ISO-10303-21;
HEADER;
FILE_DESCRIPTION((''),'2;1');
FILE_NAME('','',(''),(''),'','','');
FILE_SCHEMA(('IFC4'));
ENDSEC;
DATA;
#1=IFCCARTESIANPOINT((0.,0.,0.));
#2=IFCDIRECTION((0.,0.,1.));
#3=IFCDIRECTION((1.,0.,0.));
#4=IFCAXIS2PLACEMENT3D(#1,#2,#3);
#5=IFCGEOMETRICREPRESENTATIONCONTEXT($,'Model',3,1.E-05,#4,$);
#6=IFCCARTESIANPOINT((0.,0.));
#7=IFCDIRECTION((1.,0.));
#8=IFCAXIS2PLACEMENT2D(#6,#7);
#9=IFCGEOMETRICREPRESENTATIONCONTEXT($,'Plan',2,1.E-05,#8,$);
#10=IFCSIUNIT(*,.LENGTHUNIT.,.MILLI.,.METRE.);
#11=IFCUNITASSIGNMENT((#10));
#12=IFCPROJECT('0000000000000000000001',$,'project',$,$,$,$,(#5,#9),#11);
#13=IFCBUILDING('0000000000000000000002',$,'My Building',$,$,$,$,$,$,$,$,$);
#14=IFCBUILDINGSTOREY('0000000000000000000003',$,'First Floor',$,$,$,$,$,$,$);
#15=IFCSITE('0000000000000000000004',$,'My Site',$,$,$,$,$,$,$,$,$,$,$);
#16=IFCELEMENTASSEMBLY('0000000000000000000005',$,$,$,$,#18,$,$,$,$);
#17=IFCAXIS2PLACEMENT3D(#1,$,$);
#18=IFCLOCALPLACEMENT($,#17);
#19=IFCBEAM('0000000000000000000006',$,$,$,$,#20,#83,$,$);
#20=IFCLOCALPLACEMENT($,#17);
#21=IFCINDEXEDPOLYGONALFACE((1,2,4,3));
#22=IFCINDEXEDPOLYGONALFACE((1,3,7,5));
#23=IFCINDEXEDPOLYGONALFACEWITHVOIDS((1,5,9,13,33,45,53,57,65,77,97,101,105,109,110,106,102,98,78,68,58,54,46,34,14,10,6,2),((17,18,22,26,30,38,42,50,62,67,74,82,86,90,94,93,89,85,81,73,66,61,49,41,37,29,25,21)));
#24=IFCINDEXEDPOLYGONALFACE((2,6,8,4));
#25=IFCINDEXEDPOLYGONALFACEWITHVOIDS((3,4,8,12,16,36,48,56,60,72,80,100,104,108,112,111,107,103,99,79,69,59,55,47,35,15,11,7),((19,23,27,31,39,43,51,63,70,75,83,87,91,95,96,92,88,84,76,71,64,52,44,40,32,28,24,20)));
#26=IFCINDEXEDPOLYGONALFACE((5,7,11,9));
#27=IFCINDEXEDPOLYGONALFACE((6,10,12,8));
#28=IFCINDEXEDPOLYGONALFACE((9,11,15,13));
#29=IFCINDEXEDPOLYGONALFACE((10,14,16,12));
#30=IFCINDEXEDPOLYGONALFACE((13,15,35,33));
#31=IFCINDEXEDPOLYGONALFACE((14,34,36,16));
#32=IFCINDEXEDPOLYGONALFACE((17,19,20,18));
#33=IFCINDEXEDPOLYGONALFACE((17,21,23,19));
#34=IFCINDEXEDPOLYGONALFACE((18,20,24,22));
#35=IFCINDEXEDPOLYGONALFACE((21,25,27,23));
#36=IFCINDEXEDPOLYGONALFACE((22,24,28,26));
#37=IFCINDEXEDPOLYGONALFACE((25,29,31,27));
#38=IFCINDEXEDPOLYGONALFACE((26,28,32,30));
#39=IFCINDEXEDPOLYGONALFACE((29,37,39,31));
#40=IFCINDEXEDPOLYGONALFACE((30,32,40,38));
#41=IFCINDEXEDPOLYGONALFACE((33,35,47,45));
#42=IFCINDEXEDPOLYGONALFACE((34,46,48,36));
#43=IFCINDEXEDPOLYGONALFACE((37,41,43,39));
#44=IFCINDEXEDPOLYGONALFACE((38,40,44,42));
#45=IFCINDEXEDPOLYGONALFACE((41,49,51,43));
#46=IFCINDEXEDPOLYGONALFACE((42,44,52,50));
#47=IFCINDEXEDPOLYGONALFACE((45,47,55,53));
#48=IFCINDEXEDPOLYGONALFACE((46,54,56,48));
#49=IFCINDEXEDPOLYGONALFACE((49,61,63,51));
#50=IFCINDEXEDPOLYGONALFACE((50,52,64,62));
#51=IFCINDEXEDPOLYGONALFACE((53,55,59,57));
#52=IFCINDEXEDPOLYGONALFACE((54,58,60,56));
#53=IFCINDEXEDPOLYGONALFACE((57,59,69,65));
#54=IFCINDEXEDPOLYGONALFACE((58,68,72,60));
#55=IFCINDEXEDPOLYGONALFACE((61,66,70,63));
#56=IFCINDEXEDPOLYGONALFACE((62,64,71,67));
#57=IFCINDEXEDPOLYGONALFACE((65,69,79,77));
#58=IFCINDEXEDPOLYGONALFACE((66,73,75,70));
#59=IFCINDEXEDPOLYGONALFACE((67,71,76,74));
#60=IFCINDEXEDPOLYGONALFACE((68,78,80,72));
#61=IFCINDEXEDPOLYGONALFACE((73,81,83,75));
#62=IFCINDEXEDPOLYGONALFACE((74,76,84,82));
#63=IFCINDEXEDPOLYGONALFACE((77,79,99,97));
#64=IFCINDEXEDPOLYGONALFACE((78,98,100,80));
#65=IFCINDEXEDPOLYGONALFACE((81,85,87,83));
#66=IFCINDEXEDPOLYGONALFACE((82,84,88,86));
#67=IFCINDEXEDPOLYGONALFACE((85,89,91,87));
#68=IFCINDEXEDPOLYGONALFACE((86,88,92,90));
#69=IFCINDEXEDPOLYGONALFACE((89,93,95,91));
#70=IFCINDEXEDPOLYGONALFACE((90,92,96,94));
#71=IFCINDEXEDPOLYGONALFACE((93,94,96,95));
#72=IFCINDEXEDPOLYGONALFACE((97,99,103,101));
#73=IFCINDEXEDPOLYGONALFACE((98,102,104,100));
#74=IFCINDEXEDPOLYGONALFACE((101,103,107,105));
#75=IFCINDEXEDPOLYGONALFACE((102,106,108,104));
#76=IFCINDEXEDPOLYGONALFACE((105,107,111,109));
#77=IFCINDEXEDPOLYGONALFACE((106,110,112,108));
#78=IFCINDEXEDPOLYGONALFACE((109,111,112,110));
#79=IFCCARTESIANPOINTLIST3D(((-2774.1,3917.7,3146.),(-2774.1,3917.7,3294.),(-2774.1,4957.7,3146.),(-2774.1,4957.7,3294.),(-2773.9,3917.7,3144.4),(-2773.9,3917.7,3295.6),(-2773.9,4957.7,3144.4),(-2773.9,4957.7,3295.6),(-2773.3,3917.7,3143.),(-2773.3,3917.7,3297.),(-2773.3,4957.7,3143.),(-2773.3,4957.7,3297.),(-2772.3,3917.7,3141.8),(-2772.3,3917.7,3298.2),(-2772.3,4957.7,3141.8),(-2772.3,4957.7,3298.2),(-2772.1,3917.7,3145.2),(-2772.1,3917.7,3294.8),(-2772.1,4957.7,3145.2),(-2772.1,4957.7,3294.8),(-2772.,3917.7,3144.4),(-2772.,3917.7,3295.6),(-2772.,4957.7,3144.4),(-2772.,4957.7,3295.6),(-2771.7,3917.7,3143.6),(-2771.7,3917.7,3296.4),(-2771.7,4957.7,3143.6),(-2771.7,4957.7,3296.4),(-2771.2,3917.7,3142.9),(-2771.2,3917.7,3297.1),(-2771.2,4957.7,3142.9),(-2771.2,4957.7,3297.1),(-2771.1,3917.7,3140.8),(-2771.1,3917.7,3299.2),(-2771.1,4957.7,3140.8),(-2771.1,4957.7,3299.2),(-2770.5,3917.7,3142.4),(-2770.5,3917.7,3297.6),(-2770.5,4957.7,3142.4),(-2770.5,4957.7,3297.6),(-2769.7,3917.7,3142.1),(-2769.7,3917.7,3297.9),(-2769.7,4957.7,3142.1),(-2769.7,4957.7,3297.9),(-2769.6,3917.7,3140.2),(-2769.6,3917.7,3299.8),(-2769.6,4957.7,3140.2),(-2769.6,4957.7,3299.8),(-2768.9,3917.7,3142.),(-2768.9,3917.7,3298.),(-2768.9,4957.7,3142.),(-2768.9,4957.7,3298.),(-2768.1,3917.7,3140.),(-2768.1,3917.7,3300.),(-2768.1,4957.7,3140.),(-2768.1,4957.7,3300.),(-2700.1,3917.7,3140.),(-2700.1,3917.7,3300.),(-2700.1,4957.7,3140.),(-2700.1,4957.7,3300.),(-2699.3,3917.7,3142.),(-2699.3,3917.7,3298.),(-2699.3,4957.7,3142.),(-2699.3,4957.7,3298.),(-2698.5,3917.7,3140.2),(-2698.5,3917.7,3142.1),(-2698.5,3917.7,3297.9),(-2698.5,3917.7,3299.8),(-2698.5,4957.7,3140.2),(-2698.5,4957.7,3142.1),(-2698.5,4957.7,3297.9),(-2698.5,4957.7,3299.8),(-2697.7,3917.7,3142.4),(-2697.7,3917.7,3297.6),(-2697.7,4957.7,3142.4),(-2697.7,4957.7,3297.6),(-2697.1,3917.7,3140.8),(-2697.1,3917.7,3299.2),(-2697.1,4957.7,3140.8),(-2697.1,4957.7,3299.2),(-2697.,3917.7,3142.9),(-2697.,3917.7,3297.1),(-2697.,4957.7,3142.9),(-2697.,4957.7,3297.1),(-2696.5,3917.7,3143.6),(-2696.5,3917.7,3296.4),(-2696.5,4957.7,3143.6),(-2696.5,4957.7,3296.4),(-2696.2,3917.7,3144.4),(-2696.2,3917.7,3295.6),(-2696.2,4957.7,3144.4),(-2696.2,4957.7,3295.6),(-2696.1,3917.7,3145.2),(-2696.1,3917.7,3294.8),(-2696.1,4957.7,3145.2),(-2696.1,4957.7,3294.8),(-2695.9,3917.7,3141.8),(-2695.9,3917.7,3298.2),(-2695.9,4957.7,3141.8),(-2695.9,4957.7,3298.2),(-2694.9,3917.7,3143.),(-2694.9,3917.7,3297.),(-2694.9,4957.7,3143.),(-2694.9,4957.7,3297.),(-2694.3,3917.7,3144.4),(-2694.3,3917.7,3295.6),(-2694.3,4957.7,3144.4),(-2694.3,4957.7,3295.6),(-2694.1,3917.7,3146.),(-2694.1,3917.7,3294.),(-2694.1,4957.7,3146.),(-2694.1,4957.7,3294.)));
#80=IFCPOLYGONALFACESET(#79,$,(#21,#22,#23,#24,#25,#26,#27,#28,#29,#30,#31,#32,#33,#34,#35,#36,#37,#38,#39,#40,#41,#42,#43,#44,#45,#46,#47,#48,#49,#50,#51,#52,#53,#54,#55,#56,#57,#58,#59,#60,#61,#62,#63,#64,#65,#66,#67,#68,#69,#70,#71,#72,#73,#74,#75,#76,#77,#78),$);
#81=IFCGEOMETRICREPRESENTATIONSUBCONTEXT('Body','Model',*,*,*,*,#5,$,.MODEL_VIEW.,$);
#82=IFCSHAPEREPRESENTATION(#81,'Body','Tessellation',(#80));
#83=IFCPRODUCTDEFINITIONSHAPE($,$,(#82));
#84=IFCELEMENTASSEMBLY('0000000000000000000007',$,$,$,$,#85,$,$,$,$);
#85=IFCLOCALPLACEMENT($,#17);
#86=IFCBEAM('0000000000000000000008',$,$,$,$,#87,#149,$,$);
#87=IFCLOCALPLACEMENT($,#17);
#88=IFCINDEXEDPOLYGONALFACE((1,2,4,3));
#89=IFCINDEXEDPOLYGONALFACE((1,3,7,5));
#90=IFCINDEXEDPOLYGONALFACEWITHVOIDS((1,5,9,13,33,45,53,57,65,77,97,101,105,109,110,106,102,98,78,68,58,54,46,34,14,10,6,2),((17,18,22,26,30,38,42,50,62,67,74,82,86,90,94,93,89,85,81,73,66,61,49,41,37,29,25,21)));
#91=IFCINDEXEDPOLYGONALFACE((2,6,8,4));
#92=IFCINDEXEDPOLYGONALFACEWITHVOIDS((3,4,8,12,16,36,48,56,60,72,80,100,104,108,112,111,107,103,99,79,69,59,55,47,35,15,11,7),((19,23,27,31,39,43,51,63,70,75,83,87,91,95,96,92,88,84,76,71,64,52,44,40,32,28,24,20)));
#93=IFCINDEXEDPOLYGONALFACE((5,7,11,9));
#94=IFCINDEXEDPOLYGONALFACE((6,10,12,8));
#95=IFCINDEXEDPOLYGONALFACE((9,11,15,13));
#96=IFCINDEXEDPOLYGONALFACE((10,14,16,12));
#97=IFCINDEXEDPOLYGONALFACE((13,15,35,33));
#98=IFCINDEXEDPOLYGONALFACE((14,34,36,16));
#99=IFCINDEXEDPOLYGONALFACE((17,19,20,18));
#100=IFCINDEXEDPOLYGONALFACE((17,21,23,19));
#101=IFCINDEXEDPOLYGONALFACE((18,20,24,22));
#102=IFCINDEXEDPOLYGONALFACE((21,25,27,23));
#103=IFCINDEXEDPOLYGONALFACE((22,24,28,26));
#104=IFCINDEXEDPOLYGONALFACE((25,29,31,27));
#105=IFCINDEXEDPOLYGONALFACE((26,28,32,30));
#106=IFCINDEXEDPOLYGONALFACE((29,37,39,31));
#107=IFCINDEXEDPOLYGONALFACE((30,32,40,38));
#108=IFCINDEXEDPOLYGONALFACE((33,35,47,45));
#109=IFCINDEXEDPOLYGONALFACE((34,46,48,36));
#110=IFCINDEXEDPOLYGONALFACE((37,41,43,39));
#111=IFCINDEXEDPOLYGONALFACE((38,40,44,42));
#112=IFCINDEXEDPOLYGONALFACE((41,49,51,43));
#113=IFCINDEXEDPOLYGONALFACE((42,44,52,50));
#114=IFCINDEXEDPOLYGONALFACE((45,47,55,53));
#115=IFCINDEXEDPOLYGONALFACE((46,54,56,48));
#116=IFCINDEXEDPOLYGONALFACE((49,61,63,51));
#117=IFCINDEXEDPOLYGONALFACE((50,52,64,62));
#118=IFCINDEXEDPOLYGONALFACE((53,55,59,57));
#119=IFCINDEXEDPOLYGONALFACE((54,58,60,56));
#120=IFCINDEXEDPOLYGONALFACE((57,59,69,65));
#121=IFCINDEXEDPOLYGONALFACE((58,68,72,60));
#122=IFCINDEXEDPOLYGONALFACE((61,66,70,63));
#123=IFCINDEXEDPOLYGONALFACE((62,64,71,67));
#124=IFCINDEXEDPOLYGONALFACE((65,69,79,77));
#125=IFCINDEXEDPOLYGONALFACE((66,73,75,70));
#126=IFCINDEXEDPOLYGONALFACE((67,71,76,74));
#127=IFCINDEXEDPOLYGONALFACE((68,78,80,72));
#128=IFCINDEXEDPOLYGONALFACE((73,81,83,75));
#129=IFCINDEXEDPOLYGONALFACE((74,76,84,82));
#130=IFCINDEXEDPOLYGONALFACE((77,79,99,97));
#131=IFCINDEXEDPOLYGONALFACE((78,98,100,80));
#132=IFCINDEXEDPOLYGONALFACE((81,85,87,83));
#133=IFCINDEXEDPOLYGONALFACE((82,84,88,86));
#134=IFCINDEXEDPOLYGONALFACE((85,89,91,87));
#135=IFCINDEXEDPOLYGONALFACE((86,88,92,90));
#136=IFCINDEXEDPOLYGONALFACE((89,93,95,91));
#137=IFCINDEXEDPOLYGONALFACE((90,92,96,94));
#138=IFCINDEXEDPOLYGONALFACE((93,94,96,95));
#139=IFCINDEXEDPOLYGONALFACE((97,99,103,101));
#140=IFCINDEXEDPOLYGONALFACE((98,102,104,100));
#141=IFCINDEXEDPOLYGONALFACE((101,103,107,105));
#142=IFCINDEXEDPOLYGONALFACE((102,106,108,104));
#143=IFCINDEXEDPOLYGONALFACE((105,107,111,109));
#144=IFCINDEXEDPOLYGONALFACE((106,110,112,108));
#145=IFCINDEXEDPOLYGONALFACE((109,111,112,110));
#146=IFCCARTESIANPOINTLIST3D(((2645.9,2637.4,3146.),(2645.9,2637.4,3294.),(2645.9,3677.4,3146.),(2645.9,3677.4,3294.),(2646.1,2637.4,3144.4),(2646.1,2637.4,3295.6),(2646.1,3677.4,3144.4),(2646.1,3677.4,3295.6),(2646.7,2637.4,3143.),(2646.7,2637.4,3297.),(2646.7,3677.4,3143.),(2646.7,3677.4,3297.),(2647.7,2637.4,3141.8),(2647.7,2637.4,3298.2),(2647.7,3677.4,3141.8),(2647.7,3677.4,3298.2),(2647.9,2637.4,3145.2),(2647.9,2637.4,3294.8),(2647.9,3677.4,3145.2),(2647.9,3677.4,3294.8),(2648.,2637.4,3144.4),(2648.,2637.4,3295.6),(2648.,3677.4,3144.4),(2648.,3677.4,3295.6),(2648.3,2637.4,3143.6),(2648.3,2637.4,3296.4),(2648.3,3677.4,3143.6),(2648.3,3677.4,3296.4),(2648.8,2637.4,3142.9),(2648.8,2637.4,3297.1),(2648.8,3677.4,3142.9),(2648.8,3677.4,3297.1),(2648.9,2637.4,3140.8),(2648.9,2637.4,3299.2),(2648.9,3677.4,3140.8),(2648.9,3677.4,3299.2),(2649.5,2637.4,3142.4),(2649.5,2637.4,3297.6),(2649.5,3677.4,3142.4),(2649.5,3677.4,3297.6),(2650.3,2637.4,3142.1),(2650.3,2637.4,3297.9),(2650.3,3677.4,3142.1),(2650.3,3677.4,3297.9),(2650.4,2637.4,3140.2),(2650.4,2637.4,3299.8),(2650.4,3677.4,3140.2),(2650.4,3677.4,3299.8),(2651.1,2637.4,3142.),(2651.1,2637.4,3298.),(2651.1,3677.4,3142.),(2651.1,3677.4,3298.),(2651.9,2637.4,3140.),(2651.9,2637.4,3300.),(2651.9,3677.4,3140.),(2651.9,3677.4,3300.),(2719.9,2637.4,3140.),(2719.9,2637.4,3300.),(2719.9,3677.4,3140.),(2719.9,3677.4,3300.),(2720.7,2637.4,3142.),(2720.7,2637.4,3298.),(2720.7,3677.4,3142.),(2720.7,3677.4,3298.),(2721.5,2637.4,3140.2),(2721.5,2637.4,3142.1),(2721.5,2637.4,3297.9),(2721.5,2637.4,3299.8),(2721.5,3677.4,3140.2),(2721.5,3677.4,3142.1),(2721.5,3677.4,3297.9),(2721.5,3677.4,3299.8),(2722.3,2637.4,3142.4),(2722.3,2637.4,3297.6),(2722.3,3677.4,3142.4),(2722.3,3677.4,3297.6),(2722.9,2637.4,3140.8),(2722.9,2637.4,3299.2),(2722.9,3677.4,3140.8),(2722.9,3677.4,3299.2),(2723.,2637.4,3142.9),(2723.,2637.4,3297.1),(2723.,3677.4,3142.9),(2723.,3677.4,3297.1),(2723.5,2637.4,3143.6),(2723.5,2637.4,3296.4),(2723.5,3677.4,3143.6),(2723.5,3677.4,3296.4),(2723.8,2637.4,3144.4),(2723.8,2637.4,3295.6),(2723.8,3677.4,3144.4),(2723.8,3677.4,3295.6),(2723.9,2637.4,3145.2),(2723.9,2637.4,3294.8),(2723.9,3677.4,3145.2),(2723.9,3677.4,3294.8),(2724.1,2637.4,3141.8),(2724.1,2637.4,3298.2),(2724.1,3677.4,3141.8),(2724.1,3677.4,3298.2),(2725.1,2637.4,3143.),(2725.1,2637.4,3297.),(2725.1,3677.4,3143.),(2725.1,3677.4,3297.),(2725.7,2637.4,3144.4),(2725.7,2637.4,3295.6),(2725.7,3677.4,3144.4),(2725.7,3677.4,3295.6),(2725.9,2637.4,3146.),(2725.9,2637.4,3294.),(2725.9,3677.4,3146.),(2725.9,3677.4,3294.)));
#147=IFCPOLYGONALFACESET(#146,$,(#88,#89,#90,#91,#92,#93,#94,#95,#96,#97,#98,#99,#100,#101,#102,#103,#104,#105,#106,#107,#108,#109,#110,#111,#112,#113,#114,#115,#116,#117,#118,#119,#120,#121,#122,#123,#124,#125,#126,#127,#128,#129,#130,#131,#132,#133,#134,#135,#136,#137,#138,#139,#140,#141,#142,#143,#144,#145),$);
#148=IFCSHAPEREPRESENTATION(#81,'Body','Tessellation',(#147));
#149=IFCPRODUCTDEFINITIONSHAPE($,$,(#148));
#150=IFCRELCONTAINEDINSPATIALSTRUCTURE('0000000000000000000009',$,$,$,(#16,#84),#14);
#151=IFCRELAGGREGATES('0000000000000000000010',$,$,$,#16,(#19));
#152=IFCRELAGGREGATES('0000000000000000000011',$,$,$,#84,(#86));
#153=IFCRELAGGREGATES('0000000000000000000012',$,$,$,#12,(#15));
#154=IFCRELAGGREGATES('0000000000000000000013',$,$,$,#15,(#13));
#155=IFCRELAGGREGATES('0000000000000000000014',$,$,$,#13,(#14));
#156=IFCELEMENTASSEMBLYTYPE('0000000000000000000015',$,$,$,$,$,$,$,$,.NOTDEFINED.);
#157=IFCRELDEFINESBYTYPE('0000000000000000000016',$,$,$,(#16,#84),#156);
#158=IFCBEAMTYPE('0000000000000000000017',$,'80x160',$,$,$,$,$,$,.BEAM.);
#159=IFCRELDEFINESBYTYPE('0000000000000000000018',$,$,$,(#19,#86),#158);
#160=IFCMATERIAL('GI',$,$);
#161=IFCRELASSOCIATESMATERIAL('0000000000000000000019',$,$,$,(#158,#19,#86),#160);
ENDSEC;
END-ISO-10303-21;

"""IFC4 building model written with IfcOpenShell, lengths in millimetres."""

from ifc_helpers import new_model, si_unit, frame, origin_with_axes, origin_2d_with_axis, place, context, subcontext, project, spatial, hollow_rectangle, extrude, material, material_profile, profile_set, profile_usage, type_object, element, aggregate, save


model = new_model("IFC4")

# Units and contexts
model_context = context("Model", 3, precision=1e-05, world=origin_with_axes())
plan_context = context("Plan", 2, precision=1e-05, world=origin_2d_with_axis())
body_context = subcontext(model_context, "Body", "Model", "MODEL_VIEW")
ifc_project = project(units=[si_unit("LENGTHUNIT", "METRE", prefix="MILLI")], contexts=[model_context, plan_context])

# Site, building, storey
site = spatial("IfcSite", under=ifc_project, Name="My Site")
building = spatial("IfcBuilding", under=site, Name="My Building")
storey = spatial("IfcBuildingStorey", under=building, Name="First Floor")

# Element assemblies, beams
element_assembly_type = type_object("IfcElementAssemblyType", PredefinedType="NOTDEFINED")
ifc_material = material(Name="GI")
ifc_material_profile = material_profile(ifc_material, hollow_rectangle(XDim=80.0, YDim=160.0, WallThickness=2.0, InnerFilletRadius=3.2, OuterFilletRadius=6.0))
ifc_profile_set = profile_set([ifc_material_profile], Name="80x160 GI Rectangular Hollow")
beam_type = type_object("IfcBeamType", Name="80x160", PredefinedType="BEAM", material=ifc_profile_set)
assembly_1_placement = place(None, frame((-2734.1, 3837.7, 3220.0), z_axis=(0.0, 1.0, 0.0), x_axis=(1.0, 0.0, 0.0)))
assembly_1 = element("IfcElementAssembly", 1, at=assembly_1_placement, inside=storey, type_object=element_assembly_type)
ifc_profile_usage_1 = profile_usage(ifc_profile_set)
beam_1_placement = place(assembly_1_placement, frame((0.0, 0.0, 80.0), z_axis=(0.0, 0.0, 1.0), x_axis=(1.0, 0.0, 0.0)))
beam_1 = element("IfcBeam", 2, at=beam_1_placement, type_object=beam_type, material=ifc_profile_usage_1, context=body_context, shape_type="SweptSolid", body=[
    extrude(hollow_rectangle(XDim=80.0, YDim=160.0, WallThickness=2.0, InnerFilletRadius=3.2, OuterFilletRadius=6.0), origin_with_axes(), (0.0, 0.0, 1.0), 1040.0),
])
aggregate(assembly_1, [beam_1])
assembly_2_placement = place(None, frame((2685.9, 2557.4, 3220.0), z_axis=(0.0, 1.0, 0.0), x_axis=(1.0, 0.0, 0.0)))
assembly_2 = element("IfcElementAssembly", 3, at=assembly_2_placement, inside=storey, type_object=element_assembly_type)
ifc_profile_usage_2 = profile_usage(ifc_profile_set)
beam_2_placement = place(assembly_2_placement, frame((0.0, 0.0, 80.0), z_axis=(0.0, 0.0, 1.0), x_axis=(1.0, 0.0, 0.0)))
beam_2 = element("IfcBeam", 4, at=beam_2_placement, type_object=beam_type, material=ifc_profile_usage_2, context=body_context, shape_type="SweptSolid", body=[
    extrude(hollow_rectangle(XDim=80.0, YDim=160.0, WallThickness=2.0, InnerFilletRadius=3.2, OuterFilletRadius=6.0), origin_with_axes(), (0.0, 0.0, 1.0), 1040.0),
])
aggregate(assembly_2, [beam_2])

save(model, "model.ifc")
